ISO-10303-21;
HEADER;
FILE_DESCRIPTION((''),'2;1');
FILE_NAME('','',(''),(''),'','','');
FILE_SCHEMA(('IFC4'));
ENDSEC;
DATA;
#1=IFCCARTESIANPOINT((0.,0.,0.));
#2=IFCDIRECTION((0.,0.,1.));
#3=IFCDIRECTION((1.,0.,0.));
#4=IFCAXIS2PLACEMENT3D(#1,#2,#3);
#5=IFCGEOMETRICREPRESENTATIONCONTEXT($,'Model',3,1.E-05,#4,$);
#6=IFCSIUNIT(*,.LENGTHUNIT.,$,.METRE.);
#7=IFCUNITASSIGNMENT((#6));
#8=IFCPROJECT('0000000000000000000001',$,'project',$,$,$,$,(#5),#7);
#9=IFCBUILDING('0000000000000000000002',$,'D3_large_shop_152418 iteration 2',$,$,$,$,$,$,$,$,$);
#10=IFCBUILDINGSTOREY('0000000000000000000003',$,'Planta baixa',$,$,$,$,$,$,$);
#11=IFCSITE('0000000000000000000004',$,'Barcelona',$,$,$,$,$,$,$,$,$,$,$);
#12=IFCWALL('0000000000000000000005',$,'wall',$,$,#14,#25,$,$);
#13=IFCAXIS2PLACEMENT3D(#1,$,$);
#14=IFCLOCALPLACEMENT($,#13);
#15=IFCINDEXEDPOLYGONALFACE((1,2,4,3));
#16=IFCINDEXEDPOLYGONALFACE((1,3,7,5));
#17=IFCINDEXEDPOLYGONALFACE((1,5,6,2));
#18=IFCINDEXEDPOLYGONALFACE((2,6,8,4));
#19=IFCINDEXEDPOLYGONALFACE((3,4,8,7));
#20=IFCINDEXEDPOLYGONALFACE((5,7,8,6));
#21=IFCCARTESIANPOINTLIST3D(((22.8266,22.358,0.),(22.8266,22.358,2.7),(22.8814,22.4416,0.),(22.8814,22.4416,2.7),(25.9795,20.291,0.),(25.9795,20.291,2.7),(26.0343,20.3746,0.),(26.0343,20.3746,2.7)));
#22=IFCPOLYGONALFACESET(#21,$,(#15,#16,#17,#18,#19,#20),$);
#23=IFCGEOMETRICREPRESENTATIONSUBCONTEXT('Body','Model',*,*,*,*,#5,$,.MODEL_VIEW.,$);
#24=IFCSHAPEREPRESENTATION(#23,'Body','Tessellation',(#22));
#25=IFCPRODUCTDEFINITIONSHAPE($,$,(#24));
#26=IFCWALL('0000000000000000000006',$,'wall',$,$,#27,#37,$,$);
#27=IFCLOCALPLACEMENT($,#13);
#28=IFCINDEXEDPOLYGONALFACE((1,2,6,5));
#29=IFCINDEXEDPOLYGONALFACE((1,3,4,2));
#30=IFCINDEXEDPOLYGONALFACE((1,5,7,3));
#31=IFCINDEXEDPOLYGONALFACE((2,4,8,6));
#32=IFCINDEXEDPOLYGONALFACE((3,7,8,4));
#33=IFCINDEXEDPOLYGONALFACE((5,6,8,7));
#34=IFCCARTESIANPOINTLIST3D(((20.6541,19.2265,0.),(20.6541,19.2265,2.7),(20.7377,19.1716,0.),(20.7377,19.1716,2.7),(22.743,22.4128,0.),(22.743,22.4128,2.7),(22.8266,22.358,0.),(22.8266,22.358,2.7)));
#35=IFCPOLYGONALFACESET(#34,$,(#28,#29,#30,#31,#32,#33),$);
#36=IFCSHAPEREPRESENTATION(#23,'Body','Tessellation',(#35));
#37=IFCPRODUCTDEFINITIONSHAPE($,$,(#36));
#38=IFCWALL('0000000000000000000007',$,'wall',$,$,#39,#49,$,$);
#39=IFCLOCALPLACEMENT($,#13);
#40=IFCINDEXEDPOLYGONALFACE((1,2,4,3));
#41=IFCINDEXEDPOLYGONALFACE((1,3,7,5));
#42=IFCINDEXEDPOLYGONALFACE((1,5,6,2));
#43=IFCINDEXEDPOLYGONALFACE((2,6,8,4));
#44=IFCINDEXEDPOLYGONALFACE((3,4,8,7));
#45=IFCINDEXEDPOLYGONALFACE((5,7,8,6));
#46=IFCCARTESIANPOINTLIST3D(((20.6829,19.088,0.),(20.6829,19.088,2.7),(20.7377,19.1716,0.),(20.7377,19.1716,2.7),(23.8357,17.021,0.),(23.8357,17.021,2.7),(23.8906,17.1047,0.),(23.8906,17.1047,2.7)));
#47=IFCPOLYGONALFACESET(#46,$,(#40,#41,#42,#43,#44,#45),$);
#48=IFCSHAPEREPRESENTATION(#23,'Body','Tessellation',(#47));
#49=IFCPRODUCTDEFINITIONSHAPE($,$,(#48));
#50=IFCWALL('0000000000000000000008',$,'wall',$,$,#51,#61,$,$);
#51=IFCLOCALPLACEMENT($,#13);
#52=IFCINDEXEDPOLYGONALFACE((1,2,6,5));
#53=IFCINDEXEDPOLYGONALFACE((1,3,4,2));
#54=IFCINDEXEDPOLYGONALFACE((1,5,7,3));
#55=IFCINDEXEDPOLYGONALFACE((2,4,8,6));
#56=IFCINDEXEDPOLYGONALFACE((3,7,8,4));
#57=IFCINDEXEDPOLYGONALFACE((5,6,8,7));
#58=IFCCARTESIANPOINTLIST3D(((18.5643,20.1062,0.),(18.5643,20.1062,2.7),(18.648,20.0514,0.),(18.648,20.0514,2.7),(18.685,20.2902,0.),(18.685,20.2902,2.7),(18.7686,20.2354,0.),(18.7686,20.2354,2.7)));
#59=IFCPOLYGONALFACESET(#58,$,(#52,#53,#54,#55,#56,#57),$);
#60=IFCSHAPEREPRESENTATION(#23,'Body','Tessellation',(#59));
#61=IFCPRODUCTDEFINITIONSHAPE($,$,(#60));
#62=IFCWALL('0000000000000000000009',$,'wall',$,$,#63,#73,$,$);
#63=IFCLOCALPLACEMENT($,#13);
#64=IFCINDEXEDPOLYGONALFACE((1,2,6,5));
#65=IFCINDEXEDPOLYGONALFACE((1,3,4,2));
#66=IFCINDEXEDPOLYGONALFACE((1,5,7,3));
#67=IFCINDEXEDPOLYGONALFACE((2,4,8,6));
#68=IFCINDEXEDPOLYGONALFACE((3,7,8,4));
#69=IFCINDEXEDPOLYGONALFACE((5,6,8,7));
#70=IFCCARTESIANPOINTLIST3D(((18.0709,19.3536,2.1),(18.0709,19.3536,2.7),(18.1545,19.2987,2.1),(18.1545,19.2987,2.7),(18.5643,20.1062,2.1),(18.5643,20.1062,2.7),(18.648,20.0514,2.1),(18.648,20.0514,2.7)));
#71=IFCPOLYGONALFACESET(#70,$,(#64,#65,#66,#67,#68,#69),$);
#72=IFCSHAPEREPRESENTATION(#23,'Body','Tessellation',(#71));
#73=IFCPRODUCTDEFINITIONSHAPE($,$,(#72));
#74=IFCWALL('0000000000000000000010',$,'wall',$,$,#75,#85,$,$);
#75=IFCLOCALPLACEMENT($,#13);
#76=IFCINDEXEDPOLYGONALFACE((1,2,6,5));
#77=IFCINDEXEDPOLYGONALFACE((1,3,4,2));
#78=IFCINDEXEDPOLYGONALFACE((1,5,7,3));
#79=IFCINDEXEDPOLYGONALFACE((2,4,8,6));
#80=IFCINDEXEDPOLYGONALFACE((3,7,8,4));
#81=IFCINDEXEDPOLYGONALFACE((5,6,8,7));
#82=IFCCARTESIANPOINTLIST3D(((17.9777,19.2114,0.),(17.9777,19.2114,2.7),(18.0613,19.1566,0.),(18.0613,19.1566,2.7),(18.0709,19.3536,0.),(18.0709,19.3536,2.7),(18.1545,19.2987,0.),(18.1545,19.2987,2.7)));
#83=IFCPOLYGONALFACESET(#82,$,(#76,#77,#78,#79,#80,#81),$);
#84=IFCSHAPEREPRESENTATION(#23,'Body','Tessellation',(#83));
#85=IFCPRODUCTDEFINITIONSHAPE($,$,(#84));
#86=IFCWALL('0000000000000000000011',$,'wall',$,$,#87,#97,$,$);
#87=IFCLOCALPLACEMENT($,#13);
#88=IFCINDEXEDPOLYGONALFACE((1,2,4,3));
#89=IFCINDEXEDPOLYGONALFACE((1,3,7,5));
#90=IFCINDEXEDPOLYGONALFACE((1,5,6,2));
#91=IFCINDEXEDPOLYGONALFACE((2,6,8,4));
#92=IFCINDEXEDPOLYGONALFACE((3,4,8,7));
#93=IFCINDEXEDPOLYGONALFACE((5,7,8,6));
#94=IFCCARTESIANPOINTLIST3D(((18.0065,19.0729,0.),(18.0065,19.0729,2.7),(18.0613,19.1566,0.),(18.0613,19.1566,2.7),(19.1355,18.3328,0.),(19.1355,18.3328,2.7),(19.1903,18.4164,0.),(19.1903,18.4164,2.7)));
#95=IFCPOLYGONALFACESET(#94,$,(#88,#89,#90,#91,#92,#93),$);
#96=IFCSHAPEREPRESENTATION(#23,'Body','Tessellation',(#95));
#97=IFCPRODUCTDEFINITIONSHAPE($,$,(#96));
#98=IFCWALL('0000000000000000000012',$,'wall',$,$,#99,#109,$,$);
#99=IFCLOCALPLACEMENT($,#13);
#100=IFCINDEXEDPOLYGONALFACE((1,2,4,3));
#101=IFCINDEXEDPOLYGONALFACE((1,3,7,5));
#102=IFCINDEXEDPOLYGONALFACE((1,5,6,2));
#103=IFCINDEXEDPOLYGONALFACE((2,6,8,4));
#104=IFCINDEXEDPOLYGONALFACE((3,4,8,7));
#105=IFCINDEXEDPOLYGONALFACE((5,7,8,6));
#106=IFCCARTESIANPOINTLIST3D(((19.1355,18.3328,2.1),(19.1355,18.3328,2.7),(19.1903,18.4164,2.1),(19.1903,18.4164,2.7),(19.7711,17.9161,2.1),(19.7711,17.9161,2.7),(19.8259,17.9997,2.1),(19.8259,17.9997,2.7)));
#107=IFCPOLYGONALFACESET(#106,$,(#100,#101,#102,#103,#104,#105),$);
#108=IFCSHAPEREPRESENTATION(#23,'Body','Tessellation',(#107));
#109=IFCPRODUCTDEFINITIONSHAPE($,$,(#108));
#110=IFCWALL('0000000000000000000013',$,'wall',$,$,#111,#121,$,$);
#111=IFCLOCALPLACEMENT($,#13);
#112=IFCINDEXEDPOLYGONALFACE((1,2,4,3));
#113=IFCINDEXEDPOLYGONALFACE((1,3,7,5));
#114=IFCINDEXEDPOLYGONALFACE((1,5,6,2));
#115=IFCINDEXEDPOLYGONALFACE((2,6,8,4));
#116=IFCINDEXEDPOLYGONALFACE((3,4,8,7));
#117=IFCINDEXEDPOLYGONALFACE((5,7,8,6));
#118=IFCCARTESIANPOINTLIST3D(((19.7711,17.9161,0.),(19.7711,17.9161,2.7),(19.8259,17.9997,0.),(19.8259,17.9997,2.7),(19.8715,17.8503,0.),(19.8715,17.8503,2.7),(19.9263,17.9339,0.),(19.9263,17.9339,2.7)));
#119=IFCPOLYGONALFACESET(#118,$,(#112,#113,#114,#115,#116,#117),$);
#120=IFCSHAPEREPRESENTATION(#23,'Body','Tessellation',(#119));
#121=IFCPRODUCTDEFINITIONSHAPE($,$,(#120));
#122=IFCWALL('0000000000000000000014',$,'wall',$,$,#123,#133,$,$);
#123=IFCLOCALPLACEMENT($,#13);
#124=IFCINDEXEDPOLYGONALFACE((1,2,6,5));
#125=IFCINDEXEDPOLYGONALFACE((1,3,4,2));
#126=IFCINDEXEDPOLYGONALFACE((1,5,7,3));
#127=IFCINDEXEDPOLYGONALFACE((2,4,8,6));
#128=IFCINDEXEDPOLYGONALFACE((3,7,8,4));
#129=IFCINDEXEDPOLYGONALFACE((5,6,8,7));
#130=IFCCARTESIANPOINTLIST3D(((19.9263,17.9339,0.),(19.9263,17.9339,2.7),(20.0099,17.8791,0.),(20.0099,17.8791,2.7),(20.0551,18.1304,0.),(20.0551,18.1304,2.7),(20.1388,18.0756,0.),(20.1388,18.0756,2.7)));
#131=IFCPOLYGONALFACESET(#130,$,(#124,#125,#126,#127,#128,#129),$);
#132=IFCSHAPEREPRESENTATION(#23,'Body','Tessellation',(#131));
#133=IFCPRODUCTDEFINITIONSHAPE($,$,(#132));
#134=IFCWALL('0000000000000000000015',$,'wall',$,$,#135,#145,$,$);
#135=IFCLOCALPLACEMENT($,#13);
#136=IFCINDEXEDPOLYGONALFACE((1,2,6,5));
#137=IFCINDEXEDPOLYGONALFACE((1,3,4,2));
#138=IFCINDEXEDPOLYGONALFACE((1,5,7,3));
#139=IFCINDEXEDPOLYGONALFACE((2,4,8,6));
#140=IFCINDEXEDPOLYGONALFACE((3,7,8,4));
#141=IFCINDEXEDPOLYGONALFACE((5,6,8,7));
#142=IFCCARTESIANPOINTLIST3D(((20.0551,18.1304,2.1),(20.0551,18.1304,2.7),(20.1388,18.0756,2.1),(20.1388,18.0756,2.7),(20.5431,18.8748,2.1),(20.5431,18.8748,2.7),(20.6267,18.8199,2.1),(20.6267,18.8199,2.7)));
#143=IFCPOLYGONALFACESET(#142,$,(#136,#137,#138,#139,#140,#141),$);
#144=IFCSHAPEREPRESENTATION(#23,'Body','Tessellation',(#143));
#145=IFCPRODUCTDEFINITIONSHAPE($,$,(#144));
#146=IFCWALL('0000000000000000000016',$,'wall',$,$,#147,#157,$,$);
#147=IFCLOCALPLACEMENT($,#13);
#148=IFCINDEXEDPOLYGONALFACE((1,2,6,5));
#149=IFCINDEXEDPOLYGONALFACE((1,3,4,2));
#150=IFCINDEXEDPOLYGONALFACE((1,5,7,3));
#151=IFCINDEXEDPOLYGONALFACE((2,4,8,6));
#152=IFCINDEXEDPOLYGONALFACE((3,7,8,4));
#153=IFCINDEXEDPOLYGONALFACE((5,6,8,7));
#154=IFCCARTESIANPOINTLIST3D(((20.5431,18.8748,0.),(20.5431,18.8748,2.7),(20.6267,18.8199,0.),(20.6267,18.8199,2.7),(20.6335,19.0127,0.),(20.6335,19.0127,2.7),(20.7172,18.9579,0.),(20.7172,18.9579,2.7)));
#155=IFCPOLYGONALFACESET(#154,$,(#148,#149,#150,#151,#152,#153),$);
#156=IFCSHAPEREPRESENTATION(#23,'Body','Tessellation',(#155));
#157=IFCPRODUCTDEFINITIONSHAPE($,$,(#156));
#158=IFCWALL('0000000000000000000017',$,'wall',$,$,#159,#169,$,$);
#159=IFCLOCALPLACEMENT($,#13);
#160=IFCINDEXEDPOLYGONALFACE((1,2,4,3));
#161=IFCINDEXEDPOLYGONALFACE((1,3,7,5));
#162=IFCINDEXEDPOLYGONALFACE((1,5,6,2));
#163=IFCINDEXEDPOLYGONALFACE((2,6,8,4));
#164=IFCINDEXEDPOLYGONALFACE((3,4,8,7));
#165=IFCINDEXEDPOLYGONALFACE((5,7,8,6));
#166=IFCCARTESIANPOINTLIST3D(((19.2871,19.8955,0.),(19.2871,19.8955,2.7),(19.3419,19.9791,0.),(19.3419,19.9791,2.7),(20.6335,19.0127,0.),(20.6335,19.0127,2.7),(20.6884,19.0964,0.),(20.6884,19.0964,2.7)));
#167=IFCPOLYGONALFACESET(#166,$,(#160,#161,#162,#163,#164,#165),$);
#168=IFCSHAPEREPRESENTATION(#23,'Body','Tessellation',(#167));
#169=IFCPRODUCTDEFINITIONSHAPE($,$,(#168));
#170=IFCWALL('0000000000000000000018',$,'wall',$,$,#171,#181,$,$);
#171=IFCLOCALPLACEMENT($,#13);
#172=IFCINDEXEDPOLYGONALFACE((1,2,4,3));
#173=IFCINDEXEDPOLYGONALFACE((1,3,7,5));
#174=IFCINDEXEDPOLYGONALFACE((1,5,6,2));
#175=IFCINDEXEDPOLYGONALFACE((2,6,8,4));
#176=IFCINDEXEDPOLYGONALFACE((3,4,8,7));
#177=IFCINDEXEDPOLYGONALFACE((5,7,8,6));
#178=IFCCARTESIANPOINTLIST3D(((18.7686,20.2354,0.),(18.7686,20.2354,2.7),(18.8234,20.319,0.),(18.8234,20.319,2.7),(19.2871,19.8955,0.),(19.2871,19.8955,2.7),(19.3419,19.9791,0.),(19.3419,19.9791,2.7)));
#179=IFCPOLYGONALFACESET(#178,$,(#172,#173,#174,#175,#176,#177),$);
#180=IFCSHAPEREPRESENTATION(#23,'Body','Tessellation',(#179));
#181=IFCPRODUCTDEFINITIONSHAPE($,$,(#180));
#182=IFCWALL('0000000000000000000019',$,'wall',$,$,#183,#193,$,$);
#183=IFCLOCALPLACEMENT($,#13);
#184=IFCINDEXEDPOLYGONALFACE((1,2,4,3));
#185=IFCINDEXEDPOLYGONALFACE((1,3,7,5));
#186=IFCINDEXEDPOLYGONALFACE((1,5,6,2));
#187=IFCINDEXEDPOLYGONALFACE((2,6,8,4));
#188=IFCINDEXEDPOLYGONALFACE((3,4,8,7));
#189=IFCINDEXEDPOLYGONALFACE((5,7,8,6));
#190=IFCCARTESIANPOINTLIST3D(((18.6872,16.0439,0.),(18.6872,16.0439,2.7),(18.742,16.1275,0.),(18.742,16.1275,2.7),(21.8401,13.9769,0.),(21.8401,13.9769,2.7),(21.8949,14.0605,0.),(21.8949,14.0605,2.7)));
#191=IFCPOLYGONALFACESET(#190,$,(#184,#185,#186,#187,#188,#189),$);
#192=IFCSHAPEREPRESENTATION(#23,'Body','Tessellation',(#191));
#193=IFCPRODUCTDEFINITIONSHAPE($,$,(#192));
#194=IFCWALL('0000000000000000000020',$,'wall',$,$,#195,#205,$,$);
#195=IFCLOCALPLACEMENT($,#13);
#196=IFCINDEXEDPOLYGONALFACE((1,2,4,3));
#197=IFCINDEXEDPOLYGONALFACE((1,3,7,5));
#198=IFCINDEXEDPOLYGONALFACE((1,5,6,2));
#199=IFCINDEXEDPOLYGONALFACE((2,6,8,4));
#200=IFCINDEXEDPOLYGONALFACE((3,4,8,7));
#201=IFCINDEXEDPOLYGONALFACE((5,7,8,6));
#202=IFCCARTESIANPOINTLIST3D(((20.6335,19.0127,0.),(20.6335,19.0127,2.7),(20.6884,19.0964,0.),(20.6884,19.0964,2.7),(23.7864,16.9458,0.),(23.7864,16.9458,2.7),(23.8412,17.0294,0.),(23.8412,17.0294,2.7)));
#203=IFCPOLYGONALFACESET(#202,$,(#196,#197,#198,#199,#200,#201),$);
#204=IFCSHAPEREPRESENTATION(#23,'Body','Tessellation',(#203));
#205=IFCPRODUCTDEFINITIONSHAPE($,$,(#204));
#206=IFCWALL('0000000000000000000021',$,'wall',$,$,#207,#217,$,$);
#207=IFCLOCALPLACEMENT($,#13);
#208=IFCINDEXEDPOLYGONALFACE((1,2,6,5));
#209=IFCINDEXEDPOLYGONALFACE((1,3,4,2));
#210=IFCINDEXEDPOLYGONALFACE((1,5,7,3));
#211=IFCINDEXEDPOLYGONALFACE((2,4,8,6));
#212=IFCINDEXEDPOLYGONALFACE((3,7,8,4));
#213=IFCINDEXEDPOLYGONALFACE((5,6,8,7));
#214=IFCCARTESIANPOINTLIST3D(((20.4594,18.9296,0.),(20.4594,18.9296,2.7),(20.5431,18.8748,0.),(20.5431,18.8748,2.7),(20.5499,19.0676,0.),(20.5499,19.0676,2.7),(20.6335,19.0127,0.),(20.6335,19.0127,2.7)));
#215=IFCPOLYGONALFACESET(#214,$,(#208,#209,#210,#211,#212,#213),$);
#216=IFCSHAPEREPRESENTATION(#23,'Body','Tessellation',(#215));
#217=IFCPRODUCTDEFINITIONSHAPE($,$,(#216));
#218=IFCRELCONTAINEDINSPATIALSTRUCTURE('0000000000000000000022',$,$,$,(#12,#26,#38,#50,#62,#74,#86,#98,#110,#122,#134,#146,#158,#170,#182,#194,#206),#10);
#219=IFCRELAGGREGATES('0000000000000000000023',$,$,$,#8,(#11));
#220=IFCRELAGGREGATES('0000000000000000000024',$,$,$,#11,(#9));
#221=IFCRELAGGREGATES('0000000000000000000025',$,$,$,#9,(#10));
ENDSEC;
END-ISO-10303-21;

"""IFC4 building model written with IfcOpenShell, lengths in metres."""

from ifc_helpers import new_model, si_unit, frame, origin, origin_with_axes, place, context, subcontext, project, spatial, polyline, outline, extrude, element, save


model = new_model("IFC4")

# Units and contexts
model_context = context("Model", 3, precision=1e-05, world=origin_with_axes())
body_context = subcontext(model_context, "Body", "Model", "MODEL_VIEW")
ifc_project = project(units=[si_unit("LENGTHUNIT", "METRE")], contexts=[model_context])

# Site, building, storey
site = spatial("IfcSite", under=ifc_project, Name="Barcelona")
building = spatial("IfcBuilding", under=site, Name="D3_large_shop_152418 iteration 2")
storey = spatial("IfcBuildingStorey", under=building, Name="Planta baixa")

# Walls
wall_1_placement = place(None, origin_with_axes())
element("IfcWall", 1, at=wall_1_placement, inside=storey, Name="wall", context=body_context, shape_type="SweptSolid", body=[
    extrude(outline(polyline([(25.9795, 20.291), (22.8266, 22.358), (22.8814, 22.4416), (26.0343, 20.3746), (25.9795, 20.291)])), origin(), (0.0, 0.0, 1.0), 2.7),
])
wall_2_placement = place(None, origin_with_axes())
element("IfcWall", 2, at=wall_2_placement, inside=storey, Name="wall", context=body_context, shape_type="SweptSolid", body=[
    extrude(outline(polyline([(22.8266, 22.358), (20.7377, 19.1716), (20.6541, 19.2265), (22.743, 22.4128), (22.8266, 22.358)])), origin(), (0.0, 0.0, 1.0), 2.7),
])
wall_3_placement = place(None, origin_with_axes())
element("IfcWall", 3, at=wall_3_placement, inside=storey, Name="wall", context=body_context, shape_type="SweptSolid", body=[
    extrude(outline(polyline([(20.7377, 19.1716), (23.8906, 17.1047), (23.8357, 17.021), (20.6829, 19.088), (20.7377, 19.1716)])), origin(), (0.0, 0.0, 1.0), 2.7),
])
wall_4_placement = place(None, origin_with_axes())
element("IfcWall", 4, at=wall_4_placement, inside=storey, Name="wall", context=body_context, shape_type="SweptSolid", body=[
    extrude(outline(polyline([(18.7686, 20.2354), (18.648, 20.0514), (18.5643, 20.1062), (18.685, 20.2902), (18.7686, 20.2354)])), origin(), (0.0, 0.0, 1.0), 2.7),
])
wall_5_placement = place(None, origin_with_axes())
element("IfcWall", 5, at=wall_5_placement, inside=storey, Name="wall", context=body_context, shape_type="SweptSolid", body=[
    extrude(outline(polyline([(18.648, 20.0514), (18.1545, 19.2987), (18.0709, 19.3536), (18.5643, 20.1062), (18.648, 20.0514)])), frame((0.0, 0.0, 2.1)), (0.0, 0.0, 1.0), 0.6),
])
wall_6_placement = place(None, origin_with_axes())
element("IfcWall", 6, at=wall_6_placement, inside=storey, Name="wall", context=body_context, shape_type="SweptSolid", body=[
    extrude(outline(polyline([(18.1545, 19.2987), (18.0613, 19.1566), (17.9777, 19.2114), (18.0709, 19.3536), (18.1545, 19.2987)])), origin(), (0.0, 0.0, 1.0), 2.7),
])
wall_7_placement = place(None, origin_with_axes())
element("IfcWall", 7, at=wall_7_placement, inside=storey, Name="wall", context=body_context, shape_type="SweptSolid", body=[
    extrude(outline(polyline([(18.0613, 19.1566), (19.1903, 18.4164), (19.1355, 18.3328), (18.0065, 19.0729), (18.0613, 19.1566)])), origin(), (0.0, 0.0, 1.0), 2.7),
])
wall_8_placement = place(None, origin_with_axes())
element("IfcWall", 8, at=wall_8_placement, inside=storey, Name="wall", context=body_context, shape_type="SweptSolid", body=[
    extrude(outline(polyline([(19.1903, 18.4164), (19.8259, 17.9997), (19.7711, 17.9161), (19.1355, 18.3328), (19.1903, 18.4164)])), frame((0.0, 0.0, 2.1)), (0.0, 0.0, 1.0), 0.6),
])
wall_9_placement = place(None, origin_with_axes())
element("IfcWall", 9, at=wall_9_placement, inside=storey, Name="wall", context=body_context, shape_type="SweptSolid", body=[
    extrude(outline(polyline([(19.8259, 17.9997), (19.9263, 17.9339), (19.8715, 17.8503), (19.7711, 17.9161), (19.8259, 17.9997)])), origin(), (0.0, 0.0, 1.0), 2.7),
])
wall_10_placement = place(None, origin_with_axes())
element("IfcWall", 10, at=wall_10_placement, inside=storey, Name="wall", context=body_context, shape_type="SweptSolid", body=[
    extrude(outline(polyline([(19.9263, 17.9339), (20.0551, 18.1304), (20.1388, 18.0756), (20.0099, 17.8791), (19.9263, 17.9339)])), origin(), (0.0, 0.0, 1.0), 2.7),
])
wall_11_placement = place(None, origin_with_axes())
element("IfcWall", 11, at=wall_11_placement, inside=storey, Name="wall", context=body_context, shape_type="SweptSolid", body=[
    extrude(outline(polyline([(20.0551, 18.1304), (20.5431, 18.8748), (20.6267, 18.8199), (20.1388, 18.0756), (20.0551, 18.1304)])), frame((0.0, 0.0, 2.1)), (0.0, 0.0, 1.0), 0.6),
])
wall_12_placement = place(None, origin_with_axes())
element("IfcWall", 12, at=wall_12_placement, inside=storey, Name="wall", context=body_context, shape_type="SweptSolid", body=[
    extrude(outline(polyline([(20.5431, 18.8748), (20.6335, 19.0127), (20.7172, 18.9579), (20.6267, 18.8199), (20.5431, 18.8748)])), origin(), (0.0, 0.0, 1.0), 2.7),
])
wall_13_placement = place(None, origin_with_axes())
element("IfcWall", 13, at=wall_13_placement, inside=storey, Name="wall", context=body_context, shape_type="SweptSolid", body=[
    extrude(outline(polyline([(20.6335, 19.0127), (19.2871, 19.8955), (19.3419, 19.9791), (20.6884, 19.0964), (20.6335, 19.0127)])), origin(), (0.0, 0.0, 1.0), 2.7),
])
wall_14_placement = place(None, origin_with_axes())
element("IfcWall", 14, at=wall_14_placement, inside=storey, Name="wall", context=body_context, shape_type="SweptSolid", body=[
    extrude(outline(polyline([(19.2871, 19.8955), (18.7686, 20.2354), (18.8234, 20.319), (19.3419, 19.9791), (19.2871, 19.8955)])), origin(), (0.0, 0.0, 1.0), 2.7),
])
wall_15_placement = place(None, origin_with_axes())
element("IfcWall", 15, at=wall_15_placement, inside=storey, Name="wall", context=body_context, shape_type="SweptSolid", body=[
    extrude(outline(polyline([(18.742, 16.1275), (21.8949, 14.0605), (21.8401, 13.9769), (18.6872, 16.0439), (18.742, 16.1275)])), origin(), (0.0, 0.0, 1.0), 2.7),
])
wall_16_placement = place(None, origin_with_axes())
element("IfcWall", 16, at=wall_16_placement, inside=storey, Name="wall", context=body_context, shape_type="SweptSolid", body=[
    extrude(outline(polyline([(23.7864, 16.9458), (20.6335, 19.0127), (20.6884, 19.0964), (23.8412, 17.0294), (23.7864, 16.9458)])), origin(), (0.0, 0.0, 1.0), 2.7),
])
wall_17_placement = place(None, origin_with_axes())
element("IfcWall", 17, at=wall_17_placement, inside=storey, Name="wall", context=body_context, shape_type="SweptSolid", body=[
    extrude(outline(polyline([(20.6335, 19.0127), (20.5431, 18.8748), (20.4594, 18.9296), (20.5499, 19.0676), (20.6335, 19.0127)])), origin(), (0.0, 0.0, 1.0), 2.7),
])

save(model, "model.ifc")
